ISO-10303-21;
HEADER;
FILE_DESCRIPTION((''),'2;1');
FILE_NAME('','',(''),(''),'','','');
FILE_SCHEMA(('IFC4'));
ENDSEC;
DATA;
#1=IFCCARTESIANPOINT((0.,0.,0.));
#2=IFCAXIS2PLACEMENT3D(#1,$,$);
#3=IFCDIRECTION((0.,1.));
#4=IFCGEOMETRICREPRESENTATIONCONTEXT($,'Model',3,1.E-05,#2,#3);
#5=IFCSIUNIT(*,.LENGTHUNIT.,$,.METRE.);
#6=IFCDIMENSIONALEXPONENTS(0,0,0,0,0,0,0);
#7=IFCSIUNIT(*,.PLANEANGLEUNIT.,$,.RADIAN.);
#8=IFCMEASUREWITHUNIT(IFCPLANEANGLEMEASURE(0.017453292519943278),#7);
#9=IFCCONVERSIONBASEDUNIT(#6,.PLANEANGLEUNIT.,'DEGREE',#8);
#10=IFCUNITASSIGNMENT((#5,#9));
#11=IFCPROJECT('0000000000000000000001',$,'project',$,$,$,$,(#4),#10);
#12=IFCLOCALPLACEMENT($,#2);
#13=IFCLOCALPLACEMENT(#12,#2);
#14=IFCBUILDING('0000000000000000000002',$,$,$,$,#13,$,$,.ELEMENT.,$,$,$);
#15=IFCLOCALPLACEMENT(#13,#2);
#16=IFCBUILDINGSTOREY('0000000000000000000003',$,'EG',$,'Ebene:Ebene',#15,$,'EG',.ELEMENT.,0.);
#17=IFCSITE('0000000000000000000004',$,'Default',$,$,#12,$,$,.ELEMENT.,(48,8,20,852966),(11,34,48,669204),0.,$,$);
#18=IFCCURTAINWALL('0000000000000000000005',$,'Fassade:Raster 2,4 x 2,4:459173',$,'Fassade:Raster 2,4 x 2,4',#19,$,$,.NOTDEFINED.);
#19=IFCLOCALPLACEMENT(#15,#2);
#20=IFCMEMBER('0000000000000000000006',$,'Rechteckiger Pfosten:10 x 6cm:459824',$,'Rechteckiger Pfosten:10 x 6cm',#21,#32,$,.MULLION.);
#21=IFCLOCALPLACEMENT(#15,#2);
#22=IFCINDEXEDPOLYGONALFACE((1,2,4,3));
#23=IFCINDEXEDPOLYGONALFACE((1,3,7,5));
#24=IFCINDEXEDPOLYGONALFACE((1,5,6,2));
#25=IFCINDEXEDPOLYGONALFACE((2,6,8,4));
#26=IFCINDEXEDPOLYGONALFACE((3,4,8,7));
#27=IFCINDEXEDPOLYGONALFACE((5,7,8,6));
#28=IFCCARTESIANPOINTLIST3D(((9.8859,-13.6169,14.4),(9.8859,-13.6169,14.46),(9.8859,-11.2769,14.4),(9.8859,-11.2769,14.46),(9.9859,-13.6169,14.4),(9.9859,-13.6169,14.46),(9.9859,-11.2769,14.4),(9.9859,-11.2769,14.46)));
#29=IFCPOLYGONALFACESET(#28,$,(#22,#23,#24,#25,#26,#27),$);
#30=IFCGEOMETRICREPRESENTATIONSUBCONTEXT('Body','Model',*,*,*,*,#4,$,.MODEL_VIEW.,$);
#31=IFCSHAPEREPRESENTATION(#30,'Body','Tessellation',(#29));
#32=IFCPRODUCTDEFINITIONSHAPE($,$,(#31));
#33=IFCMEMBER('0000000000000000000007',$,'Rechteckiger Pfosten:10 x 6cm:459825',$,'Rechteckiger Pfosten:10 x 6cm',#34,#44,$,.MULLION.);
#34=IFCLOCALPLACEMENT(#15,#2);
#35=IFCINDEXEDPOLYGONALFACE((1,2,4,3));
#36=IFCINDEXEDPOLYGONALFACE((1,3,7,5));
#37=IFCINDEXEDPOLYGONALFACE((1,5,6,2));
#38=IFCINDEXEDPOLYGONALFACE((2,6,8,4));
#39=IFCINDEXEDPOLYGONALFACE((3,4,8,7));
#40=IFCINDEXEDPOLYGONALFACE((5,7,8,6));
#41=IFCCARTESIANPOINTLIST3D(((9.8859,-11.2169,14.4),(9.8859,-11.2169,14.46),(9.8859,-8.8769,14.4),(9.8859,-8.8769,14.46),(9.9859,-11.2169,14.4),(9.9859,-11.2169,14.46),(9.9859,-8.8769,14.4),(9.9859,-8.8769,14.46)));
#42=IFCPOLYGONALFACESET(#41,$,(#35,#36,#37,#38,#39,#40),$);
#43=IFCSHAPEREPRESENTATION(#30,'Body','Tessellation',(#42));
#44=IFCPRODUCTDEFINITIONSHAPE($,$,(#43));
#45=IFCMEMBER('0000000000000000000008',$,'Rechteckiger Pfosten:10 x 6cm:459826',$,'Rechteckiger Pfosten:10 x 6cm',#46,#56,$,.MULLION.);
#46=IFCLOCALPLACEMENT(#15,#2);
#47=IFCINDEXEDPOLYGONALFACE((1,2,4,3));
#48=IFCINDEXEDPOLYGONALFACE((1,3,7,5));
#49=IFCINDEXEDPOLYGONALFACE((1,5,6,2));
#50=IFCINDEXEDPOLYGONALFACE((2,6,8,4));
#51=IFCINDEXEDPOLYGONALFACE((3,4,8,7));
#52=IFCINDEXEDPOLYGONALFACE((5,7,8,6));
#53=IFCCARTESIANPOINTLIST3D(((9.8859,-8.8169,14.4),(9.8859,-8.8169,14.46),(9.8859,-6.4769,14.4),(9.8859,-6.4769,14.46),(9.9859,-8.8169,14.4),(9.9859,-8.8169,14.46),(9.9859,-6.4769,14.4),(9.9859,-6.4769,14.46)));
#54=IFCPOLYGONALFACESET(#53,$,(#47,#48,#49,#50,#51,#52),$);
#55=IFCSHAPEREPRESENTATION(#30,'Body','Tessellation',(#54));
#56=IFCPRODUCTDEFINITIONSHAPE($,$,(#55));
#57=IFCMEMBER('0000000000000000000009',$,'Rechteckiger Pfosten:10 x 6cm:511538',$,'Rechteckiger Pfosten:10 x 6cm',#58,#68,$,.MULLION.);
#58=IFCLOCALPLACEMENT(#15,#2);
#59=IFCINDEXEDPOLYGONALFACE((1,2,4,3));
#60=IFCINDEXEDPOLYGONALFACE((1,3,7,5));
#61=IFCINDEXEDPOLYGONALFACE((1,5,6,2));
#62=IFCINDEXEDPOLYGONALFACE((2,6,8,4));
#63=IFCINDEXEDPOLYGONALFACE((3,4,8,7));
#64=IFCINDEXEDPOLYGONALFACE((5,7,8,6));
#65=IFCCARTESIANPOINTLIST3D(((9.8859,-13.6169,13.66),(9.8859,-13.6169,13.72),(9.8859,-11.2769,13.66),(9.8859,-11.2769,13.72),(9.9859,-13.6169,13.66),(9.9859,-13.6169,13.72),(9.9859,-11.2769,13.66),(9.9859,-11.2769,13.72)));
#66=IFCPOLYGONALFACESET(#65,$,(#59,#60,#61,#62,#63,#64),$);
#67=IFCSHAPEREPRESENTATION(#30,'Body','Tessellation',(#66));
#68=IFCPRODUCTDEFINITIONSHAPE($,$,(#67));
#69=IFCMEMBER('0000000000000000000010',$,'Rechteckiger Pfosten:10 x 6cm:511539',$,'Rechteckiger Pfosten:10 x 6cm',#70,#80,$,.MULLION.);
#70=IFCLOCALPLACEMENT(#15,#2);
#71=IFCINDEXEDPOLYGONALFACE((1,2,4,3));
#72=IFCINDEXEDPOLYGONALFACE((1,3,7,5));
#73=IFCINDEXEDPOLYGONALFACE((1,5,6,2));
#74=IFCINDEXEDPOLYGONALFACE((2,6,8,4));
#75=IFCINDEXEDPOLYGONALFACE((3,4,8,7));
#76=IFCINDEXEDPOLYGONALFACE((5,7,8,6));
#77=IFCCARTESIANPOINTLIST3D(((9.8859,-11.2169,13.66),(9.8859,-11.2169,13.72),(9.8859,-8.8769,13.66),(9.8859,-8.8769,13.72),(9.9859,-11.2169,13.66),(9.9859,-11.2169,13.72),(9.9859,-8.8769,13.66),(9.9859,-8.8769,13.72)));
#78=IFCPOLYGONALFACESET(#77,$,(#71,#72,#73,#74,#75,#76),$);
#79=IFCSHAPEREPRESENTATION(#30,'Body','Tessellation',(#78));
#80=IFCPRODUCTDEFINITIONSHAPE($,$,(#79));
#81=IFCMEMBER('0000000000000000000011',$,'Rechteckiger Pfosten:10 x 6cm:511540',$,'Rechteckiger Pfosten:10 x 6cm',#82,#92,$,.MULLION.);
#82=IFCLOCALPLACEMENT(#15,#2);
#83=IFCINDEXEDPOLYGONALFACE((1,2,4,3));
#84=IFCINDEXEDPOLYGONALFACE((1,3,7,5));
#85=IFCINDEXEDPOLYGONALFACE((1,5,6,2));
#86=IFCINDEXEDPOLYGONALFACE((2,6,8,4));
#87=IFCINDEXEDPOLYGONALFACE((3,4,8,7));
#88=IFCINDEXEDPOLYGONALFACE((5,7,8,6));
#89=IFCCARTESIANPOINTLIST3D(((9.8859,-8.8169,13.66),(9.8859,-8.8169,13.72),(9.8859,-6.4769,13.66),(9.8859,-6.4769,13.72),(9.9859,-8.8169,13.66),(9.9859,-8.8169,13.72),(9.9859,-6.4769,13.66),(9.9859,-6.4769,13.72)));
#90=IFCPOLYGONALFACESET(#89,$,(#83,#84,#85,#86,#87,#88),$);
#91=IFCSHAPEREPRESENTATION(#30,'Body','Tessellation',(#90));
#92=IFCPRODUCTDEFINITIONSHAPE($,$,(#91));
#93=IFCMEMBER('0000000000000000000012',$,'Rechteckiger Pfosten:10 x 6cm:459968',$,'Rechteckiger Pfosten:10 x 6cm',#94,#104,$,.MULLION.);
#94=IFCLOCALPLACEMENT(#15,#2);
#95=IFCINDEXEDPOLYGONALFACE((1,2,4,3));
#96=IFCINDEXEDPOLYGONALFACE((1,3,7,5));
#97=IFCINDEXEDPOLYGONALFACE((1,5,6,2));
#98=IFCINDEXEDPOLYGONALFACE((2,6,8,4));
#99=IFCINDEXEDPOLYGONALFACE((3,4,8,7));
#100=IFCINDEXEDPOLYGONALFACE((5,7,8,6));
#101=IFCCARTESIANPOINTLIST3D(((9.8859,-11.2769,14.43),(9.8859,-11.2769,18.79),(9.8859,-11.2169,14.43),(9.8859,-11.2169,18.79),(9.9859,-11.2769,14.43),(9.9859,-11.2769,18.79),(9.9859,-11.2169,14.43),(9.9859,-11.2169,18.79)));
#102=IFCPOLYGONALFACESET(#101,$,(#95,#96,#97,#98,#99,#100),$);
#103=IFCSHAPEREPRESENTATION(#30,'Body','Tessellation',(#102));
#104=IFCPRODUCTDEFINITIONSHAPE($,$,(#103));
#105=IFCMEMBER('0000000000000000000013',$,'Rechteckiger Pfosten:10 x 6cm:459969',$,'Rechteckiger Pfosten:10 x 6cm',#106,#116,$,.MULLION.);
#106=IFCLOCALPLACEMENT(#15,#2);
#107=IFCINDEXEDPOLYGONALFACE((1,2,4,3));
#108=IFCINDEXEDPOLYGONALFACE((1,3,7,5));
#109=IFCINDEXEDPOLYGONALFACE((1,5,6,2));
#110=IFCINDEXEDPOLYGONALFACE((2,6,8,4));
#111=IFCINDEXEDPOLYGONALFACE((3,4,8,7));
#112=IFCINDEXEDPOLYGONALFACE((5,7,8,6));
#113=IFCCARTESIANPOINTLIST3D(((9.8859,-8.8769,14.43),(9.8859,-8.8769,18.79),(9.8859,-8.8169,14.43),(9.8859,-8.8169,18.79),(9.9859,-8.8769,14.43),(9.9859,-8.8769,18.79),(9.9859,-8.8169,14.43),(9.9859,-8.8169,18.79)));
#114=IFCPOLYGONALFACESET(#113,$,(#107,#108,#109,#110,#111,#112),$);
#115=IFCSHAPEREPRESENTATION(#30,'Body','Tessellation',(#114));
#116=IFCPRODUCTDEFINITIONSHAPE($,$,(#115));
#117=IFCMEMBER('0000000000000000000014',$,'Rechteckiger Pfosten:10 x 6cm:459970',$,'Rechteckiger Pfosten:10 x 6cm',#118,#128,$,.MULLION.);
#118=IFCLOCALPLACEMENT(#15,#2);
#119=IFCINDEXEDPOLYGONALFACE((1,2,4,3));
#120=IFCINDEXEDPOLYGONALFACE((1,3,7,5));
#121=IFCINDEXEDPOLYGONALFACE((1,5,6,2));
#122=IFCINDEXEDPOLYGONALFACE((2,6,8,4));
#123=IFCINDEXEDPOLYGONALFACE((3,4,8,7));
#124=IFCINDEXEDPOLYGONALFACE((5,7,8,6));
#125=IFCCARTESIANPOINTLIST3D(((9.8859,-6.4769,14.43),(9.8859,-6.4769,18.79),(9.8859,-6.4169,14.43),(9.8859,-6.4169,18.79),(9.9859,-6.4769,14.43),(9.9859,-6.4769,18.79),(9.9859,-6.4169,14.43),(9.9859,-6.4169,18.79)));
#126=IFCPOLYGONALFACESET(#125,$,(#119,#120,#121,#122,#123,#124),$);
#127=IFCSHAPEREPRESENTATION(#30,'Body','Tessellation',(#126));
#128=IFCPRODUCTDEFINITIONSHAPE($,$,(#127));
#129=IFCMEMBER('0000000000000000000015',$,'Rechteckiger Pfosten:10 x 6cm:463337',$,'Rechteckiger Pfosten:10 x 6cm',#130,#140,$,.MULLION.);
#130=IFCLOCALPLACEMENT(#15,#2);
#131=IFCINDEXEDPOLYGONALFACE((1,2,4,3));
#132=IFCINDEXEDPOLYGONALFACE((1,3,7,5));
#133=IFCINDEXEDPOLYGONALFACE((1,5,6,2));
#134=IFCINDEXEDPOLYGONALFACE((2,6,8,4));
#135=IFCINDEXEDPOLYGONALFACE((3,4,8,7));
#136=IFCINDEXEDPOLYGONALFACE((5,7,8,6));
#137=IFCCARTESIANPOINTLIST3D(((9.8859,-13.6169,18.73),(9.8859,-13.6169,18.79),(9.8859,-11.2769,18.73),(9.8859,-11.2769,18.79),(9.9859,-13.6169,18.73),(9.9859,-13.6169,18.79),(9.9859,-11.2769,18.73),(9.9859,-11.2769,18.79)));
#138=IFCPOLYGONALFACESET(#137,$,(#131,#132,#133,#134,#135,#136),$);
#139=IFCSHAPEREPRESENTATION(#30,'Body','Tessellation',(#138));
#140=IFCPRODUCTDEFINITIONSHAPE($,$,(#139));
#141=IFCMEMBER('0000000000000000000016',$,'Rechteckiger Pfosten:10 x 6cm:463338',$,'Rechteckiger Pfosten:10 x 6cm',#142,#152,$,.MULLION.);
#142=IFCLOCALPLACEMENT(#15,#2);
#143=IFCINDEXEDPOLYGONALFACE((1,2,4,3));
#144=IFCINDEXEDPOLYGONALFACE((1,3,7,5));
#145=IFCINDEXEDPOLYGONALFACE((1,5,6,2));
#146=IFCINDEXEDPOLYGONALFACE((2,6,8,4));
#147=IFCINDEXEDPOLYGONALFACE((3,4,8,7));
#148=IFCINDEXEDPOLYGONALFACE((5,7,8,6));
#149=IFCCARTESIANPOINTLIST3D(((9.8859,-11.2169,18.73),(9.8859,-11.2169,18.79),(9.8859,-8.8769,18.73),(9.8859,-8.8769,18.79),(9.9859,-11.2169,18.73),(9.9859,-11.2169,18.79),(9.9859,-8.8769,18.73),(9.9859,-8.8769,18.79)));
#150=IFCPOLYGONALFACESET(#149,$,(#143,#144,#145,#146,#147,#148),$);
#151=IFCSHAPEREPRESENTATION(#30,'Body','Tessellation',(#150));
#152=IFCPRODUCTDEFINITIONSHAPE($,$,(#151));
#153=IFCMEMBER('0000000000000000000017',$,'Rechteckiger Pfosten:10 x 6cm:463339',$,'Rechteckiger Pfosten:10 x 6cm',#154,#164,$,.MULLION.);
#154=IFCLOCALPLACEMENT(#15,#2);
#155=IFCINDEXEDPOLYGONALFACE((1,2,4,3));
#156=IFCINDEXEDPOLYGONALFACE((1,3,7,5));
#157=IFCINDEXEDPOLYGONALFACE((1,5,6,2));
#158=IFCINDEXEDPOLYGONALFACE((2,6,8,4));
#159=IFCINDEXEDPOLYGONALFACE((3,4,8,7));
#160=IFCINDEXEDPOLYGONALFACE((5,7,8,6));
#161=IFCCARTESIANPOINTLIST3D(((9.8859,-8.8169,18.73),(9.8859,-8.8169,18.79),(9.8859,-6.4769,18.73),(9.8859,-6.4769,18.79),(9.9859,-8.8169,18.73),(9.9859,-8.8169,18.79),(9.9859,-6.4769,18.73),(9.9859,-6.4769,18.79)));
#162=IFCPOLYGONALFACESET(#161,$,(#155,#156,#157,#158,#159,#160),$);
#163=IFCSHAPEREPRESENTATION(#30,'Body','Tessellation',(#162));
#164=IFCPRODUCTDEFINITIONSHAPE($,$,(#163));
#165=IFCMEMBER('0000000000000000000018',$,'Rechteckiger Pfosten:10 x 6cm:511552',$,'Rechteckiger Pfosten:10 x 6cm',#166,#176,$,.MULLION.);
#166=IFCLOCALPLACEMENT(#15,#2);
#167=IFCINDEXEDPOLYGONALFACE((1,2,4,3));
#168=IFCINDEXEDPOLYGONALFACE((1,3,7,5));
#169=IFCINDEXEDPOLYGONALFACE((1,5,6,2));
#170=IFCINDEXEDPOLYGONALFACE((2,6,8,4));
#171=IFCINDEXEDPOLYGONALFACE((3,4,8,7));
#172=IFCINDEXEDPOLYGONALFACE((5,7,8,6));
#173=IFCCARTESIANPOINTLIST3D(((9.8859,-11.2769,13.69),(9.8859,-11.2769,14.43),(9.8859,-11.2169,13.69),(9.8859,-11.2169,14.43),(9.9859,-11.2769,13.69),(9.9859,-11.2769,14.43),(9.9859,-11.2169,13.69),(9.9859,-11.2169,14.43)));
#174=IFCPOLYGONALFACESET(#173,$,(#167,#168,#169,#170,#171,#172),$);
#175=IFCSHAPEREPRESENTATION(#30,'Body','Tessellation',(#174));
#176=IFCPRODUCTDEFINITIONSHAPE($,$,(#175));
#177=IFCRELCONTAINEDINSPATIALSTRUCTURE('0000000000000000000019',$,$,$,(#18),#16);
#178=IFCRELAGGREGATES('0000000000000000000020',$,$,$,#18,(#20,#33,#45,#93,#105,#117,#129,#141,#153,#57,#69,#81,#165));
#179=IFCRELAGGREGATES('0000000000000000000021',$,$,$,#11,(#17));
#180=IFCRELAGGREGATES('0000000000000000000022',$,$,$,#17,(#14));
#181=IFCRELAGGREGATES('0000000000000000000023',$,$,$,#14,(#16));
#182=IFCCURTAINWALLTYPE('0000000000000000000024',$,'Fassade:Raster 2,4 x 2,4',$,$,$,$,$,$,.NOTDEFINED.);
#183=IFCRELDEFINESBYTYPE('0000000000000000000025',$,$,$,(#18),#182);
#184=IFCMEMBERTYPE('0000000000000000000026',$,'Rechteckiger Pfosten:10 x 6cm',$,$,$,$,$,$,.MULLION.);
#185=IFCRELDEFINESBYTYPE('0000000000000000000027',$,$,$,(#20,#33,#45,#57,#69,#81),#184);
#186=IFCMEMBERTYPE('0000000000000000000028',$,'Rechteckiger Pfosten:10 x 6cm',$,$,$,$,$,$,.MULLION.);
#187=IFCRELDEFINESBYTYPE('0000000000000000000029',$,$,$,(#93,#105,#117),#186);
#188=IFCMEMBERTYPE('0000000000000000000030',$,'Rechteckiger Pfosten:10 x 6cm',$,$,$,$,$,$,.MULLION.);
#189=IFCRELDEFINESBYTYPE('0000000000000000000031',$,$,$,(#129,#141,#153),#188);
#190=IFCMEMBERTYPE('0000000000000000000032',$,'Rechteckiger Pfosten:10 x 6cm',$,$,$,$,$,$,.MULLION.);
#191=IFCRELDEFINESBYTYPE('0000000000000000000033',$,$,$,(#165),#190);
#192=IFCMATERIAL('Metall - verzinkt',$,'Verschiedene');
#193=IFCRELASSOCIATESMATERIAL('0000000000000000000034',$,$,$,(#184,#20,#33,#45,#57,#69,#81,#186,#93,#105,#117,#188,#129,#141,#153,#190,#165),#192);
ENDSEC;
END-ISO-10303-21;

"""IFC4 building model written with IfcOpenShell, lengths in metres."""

from ifc_helpers import new_model, entity, si_unit, converted_unit, direction, frame, origin, place, context, subcontext, project, spatial, indexed_curve, outline, extrude, source, transform, mapped, material, type_object, type_shapes, element, aggregate, save


model = new_model("IFC4")

# Units and contexts
model_context = context("Model", 3, precision=1e-05, world=origin(), true_north=direction((0.0, 1.0)))
body_context = subcontext(model_context, "Body", "Model", "MODEL_VIEW")
ifc_project = project(units=[si_unit("LENGTHUNIT", "METRE"), converted_unit("PLANEANGLEUNIT", "DEGREE", entity("IfcPlaneAngleMeasure", 0.017453292519943278), si_unit("PLANEANGLEUNIT", "RADIAN"), dimensions=[0, 0, 0, 0, 0, 0, 0])], contexts=[model_context])

# Site, building, storey
site_placement = place(None, origin())
site = spatial("IfcSite", under=ifc_project, at=site_placement, Name="Default", CompositionType="ELEMENT", RefLatitude=(48, 8, 20, 852966), RefLongitude=(11, 34, 48, 669204), RefElevation=0.0)
building_placement = place(site_placement, origin())
building = spatial("IfcBuilding", under=site, at=building_placement, CompositionType="ELEMENT")
storey_placement = place(building_placement, origin())
storey = spatial("IfcBuildingStorey", under=building, at=storey_placement, Name="EG", ObjectType="Ebene:Ebene", LongName="EG", CompositionType="ELEMENT", Elevation=0.0)

# Curtain wall, members
curtain_wall_type = type_object("IfcCurtainWallType", Name="Fassade:Raster 2,4 x 2,4", PredefinedType="NOTDEFINED")
curtain_wall_placement = place(storey_placement, origin())
curtain_wall = element("IfcCurtainWall", 1, at=curtain_wall_placement, inside=storey, type_object=curtain_wall_type, Name="Fassade:Raster 2,4 x 2,4:459173", ObjectType="Fassade:Raster 2,4 x 2,4", PredefinedType="NOTDEFINED")
ifc_material_1 = material(Name="Metall - verzinkt", Category="Verschiedene")
member_type_1 = type_object("IfcMemberType", Name="Rechteckiger Pfosten:10 x 6cm", PredefinedType="MULLION", material=ifc_material_1)
shared_shape_1 = source(origin(), body_context, "Body", "SweptSolid", [
    extrude(outline(indexed_curve([(-0.03, -0.05), (0.03, -0.05), (0.03, 0.05), (-0.03, 0.05), (-0.03, -0.05)], self_intersect=False)), frame((0.0, 0.0, -2.34), z_axis=(0.0, 0.0, 1.0), x_axis=(-1.0, 0.0, 0.0)), (0.0, 0.0, 1.0), 2.34),
])
type_shapes(member_type_1, [shared_shape_1])
member_1_placement = place(curtain_wall_placement, frame((9.9359, -11.2769, 14.43), z_axis=(0.0, 1.0, 0.0), x_axis=(0.0, 0.0, 1.0)))
member_1 = element("IfcMember", 2, at=member_1_placement, type_object=member_type_1, material=ifc_material_1, Name="Rechteckiger Pfosten:10 x 6cm:459824", ObjectType="Rechteckiger Pfosten:10 x 6cm", PredefinedType="MULLION", context=body_context, shape_type="MappedRepresentation", body=[
    mapped(shared_shape_1, transform((0.0, 0.0, 0.0), scale=1.0)),
])
member_2_placement = place(curtain_wall_placement, frame((9.9359, -8.8769, 14.43), z_axis=(0.0, 1.0, 0.0), x_axis=(0.0, 0.0, 1.0)))
member_2 = element("IfcMember", 3, at=member_2_placement, type_object=member_type_1, material=ifc_material_1, Name="Rechteckiger Pfosten:10 x 6cm:459825", ObjectType="Rechteckiger Pfosten:10 x 6cm", PredefinedType="MULLION", context=body_context, shape_type="MappedRepresentation", body=[
    mapped(shared_shape_1, transform((0.0, 0.0, 0.0), scale=1.0)),
])
member_3_placement = place(curtain_wall_placement, frame((9.9359, -6.4769, 14.43), z_axis=(0.0, 1.0, 0.0), x_axis=(0.0, 0.0, 1.0)))
member_3 = element("IfcMember", 4, at=member_3_placement, type_object=member_type_1, material=ifc_material_1, Name="Rechteckiger Pfosten:10 x 6cm:459826", ObjectType="Rechteckiger Pfosten:10 x 6cm", PredefinedType="MULLION", context=body_context, shape_type="MappedRepresentation", body=[
    mapped(shared_shape_1, transform((0.0, 0.0, 0.0), scale=1.0)),
])
member_4_placement = place(curtain_wall_placement, frame((9.9359, -11.2769, 13.69), z_axis=(0.0, 1.0, 0.0), x_axis=(0.0, 0.0, 1.0)))
member_4 = element("IfcMember", 5, at=member_4_placement, type_object=member_type_1, material=ifc_material_1, Name="Rechteckiger Pfosten:10 x 6cm:511538", ObjectType="Rechteckiger Pfosten:10 x 6cm", PredefinedType="MULLION", context=body_context, shape_type="MappedRepresentation", body=[
    mapped(shared_shape_1, transform((0.0, 0.0, 0.0), scale=1.0)),
])
member_5_placement = place(curtain_wall_placement, frame((9.9359, -8.8769, 13.69), z_axis=(0.0, 1.0, 0.0), x_axis=(0.0, 0.0, 1.0)))
member_5 = element("IfcMember", 6, at=member_5_placement, type_object=member_type_1, material=ifc_material_1, Name="Rechteckiger Pfosten:10 x 6cm:511539", ObjectType="Rechteckiger Pfosten:10 x 6cm", PredefinedType="MULLION", context=body_context, shape_type="MappedRepresentation", body=[
    mapped(shared_shape_1, transform((0.0, 0.0, 0.0), scale=1.0)),
])
member_6_placement = place(curtain_wall_placement, frame((9.9359, -6.4769, 13.69), z_axis=(0.0, 1.0, 0.0), x_axis=(0.0, 0.0, 1.0)))
member_6 = element("IfcMember", 7, at=member_6_placement, type_object=member_type_1, material=ifc_material_1, Name="Rechteckiger Pfosten:10 x 6cm:511540", ObjectType="Rechteckiger Pfosten:10 x 6cm", PredefinedType="MULLION", context=body_context, shape_type="MappedRepresentation", body=[
    mapped(shared_shape_1, transform((0.0, 0.0, 0.0), scale=1.0)),
])
member_type_2 = type_object("IfcMemberType", Name="Rechteckiger Pfosten:10 x 6cm", PredefinedType="MULLION", material=ifc_material_1)
shared_shape_2 = source(origin(), body_context, "Body", "SweptSolid", [
    extrude(outline(indexed_curve([(-0.03, -0.05), (0.03, -0.05), (0.03, 0.05), (-0.03, 0.05), (-0.03, -0.05)], self_intersect=False)), frame((0.0, 0.0, -4.36), z_axis=(0.0, 0.0, 1.0), x_axis=(-1.0, 0.0, 0.0)), (0.0, 0.0, 1.0), 4.36),
])
type_shapes(member_type_2, [shared_shape_2])
member_7_placement = place(curtain_wall_placement, frame((9.9359, -11.2469, 14.43), z_axis=(0.0, 0.0, -1.0), x_axis=(0.0, 1.0, 0.0)))
member_7 = element("IfcMember", 8, at=member_7_placement, type_object=member_type_2, material=ifc_material_1, Name="Rechteckiger Pfosten:10 x 6cm:459968", ObjectType="Rechteckiger Pfosten:10 x 6cm", PredefinedType="MULLION", context=body_context, shape_type="MappedRepresentation", body=[
    mapped(shared_shape_2, transform((0.0, 0.0, 0.0), scale=1.0)),
])
member_8_placement = place(curtain_wall_placement, frame((9.9359, -8.8469, 14.43), z_axis=(0.0, 0.0, -1.0), x_axis=(0.0, 1.0, 0.0)))
member_8 = element("IfcMember", 9, at=member_8_placement, type_object=member_type_2, material=ifc_material_1, Name="Rechteckiger Pfosten:10 x 6cm:459969", ObjectType="Rechteckiger Pfosten:10 x 6cm", PredefinedType="MULLION", context=body_context, shape_type="MappedRepresentation", body=[
    mapped(shared_shape_2, transform((0.0, 0.0, 0.0), scale=1.0)),
])
member_9_placement = place(curtain_wall_placement, frame((9.9359, -6.4469, 14.43), z_axis=(0.0, 0.0, -1.0), x_axis=(0.0, 1.0, 0.0)))
member_9 = element("IfcMember", 10, at=member_9_placement, type_object=member_type_2, material=ifc_material_1, Name="Rechteckiger Pfosten:10 x 6cm:459970", ObjectType="Rechteckiger Pfosten:10 x 6cm", PredefinedType="MULLION", context=body_context, shape_type="MappedRepresentation", body=[
    mapped(shared_shape_2, transform((0.0, 0.0, 0.0), scale=1.0)),
])
member_type_3 = type_object("IfcMemberType", Name="Rechteckiger Pfosten:10 x 6cm", PredefinedType="MULLION", material=ifc_material_1)
shared_shape_3 = source(origin(), body_context, "Body", "SweptSolid", [
    extrude(outline(indexed_curve([(-0.03, -0.05), (0.03, -0.05), (0.03, 0.05), (-0.03, 0.05), (-0.03, -0.05)], self_intersect=False)), frame((-0.03, 0.0, -2.34), z_axis=(0.0, 0.0, 1.0), x_axis=(-1.0, 0.0, 0.0)), (0.0, 0.0, 1.0), 2.34),
])
type_shapes(member_type_3, [shared_shape_3])
member_10_placement = place(curtain_wall_placement, frame((9.9359, -11.2769, 18.79), z_axis=(0.0, 1.0, 0.0), x_axis=(0.0, 0.0, 1.0)))
member_10 = element("IfcMember", 11, at=member_10_placement, type_object=member_type_3, material=ifc_material_1, Name="Rechteckiger Pfosten:10 x 6cm:463337", ObjectType="Rechteckiger Pfosten:10 x 6cm", PredefinedType="MULLION", context=body_context, shape_type="MappedRepresentation", body=[
    mapped(shared_shape_3, transform((0.0, 0.0, 0.0), scale=1.0)),
])
member_11_placement = place(curtain_wall_placement, frame((9.9359, -8.8769, 18.79), z_axis=(0.0, 1.0, 0.0), x_axis=(0.0, 0.0, 1.0)))
member_11 = element("IfcMember", 12, at=member_11_placement, type_object=member_type_3, material=ifc_material_1, Name="Rechteckiger Pfosten:10 x 6cm:463338", ObjectType="Rechteckiger Pfosten:10 x 6cm", PredefinedType="MULLION", context=body_context, shape_type="MappedRepresentation", body=[
    mapped(shared_shape_3, transform((0.0, 0.0, 0.0), scale=1.0)),
])
member_12_placement = place(curtain_wall_placement, frame((9.9359, -6.4769, 18.79), z_axis=(0.0, 1.0, 0.0), x_axis=(0.0, 0.0, 1.0)))
member_12 = element("IfcMember", 13, at=member_12_placement, type_object=member_type_3, material=ifc_material_1, Name="Rechteckiger Pfosten:10 x 6cm:463339", ObjectType="Rechteckiger Pfosten:10 x 6cm", PredefinedType="MULLION", context=body_context, shape_type="MappedRepresentation", body=[
    mapped(shared_shape_3, transform((0.0, 0.0, 0.0), scale=1.0)),
])
member_type_4 = type_object("IfcMemberType", Name="Rechteckiger Pfosten:10 x 6cm", PredefinedType="MULLION", material=ifc_material_1)
shared_shape_4 = source(origin(), body_context, "Body", "SweptSolid", [
    extrude(outline(indexed_curve([(-0.03, -0.05), (0.03, -0.05), (0.03, 0.05), (-0.03, 0.05), (-0.03, -0.05)], self_intersect=False)), frame((0.0, 0.0, -0.74), z_axis=(0.0, 0.0, 1.0), x_axis=(-1.0, 0.0, 0.0)), (0.0, 0.0, 1.0), 0.74),
])
type_shapes(member_type_4, [shared_shape_4])
member_13_placement = place(curtain_wall_placement, frame((9.9359, -11.2469, 13.69), z_axis=(0.0, 0.0, -1.0), x_axis=(0.0, 1.0, 0.0)))
member_13 = element("IfcMember", 14, at=member_13_placement, type_object=member_type_4, material=ifc_material_1, Name="Rechteckiger Pfosten:10 x 6cm:511552", ObjectType="Rechteckiger Pfosten:10 x 6cm", PredefinedType="MULLION", context=body_context, shape_type="MappedRepresentation", body=[
    mapped(shared_shape_4, transform((0.0, 0.0, 0.0), scale=1.0)),
])
aggregate(curtain_wall, [member_1, member_2, member_3, member_7, member_8, member_9, member_10, member_11, member_12, member_4, member_5, member_6, member_13])

save(model, "model.ifc")
